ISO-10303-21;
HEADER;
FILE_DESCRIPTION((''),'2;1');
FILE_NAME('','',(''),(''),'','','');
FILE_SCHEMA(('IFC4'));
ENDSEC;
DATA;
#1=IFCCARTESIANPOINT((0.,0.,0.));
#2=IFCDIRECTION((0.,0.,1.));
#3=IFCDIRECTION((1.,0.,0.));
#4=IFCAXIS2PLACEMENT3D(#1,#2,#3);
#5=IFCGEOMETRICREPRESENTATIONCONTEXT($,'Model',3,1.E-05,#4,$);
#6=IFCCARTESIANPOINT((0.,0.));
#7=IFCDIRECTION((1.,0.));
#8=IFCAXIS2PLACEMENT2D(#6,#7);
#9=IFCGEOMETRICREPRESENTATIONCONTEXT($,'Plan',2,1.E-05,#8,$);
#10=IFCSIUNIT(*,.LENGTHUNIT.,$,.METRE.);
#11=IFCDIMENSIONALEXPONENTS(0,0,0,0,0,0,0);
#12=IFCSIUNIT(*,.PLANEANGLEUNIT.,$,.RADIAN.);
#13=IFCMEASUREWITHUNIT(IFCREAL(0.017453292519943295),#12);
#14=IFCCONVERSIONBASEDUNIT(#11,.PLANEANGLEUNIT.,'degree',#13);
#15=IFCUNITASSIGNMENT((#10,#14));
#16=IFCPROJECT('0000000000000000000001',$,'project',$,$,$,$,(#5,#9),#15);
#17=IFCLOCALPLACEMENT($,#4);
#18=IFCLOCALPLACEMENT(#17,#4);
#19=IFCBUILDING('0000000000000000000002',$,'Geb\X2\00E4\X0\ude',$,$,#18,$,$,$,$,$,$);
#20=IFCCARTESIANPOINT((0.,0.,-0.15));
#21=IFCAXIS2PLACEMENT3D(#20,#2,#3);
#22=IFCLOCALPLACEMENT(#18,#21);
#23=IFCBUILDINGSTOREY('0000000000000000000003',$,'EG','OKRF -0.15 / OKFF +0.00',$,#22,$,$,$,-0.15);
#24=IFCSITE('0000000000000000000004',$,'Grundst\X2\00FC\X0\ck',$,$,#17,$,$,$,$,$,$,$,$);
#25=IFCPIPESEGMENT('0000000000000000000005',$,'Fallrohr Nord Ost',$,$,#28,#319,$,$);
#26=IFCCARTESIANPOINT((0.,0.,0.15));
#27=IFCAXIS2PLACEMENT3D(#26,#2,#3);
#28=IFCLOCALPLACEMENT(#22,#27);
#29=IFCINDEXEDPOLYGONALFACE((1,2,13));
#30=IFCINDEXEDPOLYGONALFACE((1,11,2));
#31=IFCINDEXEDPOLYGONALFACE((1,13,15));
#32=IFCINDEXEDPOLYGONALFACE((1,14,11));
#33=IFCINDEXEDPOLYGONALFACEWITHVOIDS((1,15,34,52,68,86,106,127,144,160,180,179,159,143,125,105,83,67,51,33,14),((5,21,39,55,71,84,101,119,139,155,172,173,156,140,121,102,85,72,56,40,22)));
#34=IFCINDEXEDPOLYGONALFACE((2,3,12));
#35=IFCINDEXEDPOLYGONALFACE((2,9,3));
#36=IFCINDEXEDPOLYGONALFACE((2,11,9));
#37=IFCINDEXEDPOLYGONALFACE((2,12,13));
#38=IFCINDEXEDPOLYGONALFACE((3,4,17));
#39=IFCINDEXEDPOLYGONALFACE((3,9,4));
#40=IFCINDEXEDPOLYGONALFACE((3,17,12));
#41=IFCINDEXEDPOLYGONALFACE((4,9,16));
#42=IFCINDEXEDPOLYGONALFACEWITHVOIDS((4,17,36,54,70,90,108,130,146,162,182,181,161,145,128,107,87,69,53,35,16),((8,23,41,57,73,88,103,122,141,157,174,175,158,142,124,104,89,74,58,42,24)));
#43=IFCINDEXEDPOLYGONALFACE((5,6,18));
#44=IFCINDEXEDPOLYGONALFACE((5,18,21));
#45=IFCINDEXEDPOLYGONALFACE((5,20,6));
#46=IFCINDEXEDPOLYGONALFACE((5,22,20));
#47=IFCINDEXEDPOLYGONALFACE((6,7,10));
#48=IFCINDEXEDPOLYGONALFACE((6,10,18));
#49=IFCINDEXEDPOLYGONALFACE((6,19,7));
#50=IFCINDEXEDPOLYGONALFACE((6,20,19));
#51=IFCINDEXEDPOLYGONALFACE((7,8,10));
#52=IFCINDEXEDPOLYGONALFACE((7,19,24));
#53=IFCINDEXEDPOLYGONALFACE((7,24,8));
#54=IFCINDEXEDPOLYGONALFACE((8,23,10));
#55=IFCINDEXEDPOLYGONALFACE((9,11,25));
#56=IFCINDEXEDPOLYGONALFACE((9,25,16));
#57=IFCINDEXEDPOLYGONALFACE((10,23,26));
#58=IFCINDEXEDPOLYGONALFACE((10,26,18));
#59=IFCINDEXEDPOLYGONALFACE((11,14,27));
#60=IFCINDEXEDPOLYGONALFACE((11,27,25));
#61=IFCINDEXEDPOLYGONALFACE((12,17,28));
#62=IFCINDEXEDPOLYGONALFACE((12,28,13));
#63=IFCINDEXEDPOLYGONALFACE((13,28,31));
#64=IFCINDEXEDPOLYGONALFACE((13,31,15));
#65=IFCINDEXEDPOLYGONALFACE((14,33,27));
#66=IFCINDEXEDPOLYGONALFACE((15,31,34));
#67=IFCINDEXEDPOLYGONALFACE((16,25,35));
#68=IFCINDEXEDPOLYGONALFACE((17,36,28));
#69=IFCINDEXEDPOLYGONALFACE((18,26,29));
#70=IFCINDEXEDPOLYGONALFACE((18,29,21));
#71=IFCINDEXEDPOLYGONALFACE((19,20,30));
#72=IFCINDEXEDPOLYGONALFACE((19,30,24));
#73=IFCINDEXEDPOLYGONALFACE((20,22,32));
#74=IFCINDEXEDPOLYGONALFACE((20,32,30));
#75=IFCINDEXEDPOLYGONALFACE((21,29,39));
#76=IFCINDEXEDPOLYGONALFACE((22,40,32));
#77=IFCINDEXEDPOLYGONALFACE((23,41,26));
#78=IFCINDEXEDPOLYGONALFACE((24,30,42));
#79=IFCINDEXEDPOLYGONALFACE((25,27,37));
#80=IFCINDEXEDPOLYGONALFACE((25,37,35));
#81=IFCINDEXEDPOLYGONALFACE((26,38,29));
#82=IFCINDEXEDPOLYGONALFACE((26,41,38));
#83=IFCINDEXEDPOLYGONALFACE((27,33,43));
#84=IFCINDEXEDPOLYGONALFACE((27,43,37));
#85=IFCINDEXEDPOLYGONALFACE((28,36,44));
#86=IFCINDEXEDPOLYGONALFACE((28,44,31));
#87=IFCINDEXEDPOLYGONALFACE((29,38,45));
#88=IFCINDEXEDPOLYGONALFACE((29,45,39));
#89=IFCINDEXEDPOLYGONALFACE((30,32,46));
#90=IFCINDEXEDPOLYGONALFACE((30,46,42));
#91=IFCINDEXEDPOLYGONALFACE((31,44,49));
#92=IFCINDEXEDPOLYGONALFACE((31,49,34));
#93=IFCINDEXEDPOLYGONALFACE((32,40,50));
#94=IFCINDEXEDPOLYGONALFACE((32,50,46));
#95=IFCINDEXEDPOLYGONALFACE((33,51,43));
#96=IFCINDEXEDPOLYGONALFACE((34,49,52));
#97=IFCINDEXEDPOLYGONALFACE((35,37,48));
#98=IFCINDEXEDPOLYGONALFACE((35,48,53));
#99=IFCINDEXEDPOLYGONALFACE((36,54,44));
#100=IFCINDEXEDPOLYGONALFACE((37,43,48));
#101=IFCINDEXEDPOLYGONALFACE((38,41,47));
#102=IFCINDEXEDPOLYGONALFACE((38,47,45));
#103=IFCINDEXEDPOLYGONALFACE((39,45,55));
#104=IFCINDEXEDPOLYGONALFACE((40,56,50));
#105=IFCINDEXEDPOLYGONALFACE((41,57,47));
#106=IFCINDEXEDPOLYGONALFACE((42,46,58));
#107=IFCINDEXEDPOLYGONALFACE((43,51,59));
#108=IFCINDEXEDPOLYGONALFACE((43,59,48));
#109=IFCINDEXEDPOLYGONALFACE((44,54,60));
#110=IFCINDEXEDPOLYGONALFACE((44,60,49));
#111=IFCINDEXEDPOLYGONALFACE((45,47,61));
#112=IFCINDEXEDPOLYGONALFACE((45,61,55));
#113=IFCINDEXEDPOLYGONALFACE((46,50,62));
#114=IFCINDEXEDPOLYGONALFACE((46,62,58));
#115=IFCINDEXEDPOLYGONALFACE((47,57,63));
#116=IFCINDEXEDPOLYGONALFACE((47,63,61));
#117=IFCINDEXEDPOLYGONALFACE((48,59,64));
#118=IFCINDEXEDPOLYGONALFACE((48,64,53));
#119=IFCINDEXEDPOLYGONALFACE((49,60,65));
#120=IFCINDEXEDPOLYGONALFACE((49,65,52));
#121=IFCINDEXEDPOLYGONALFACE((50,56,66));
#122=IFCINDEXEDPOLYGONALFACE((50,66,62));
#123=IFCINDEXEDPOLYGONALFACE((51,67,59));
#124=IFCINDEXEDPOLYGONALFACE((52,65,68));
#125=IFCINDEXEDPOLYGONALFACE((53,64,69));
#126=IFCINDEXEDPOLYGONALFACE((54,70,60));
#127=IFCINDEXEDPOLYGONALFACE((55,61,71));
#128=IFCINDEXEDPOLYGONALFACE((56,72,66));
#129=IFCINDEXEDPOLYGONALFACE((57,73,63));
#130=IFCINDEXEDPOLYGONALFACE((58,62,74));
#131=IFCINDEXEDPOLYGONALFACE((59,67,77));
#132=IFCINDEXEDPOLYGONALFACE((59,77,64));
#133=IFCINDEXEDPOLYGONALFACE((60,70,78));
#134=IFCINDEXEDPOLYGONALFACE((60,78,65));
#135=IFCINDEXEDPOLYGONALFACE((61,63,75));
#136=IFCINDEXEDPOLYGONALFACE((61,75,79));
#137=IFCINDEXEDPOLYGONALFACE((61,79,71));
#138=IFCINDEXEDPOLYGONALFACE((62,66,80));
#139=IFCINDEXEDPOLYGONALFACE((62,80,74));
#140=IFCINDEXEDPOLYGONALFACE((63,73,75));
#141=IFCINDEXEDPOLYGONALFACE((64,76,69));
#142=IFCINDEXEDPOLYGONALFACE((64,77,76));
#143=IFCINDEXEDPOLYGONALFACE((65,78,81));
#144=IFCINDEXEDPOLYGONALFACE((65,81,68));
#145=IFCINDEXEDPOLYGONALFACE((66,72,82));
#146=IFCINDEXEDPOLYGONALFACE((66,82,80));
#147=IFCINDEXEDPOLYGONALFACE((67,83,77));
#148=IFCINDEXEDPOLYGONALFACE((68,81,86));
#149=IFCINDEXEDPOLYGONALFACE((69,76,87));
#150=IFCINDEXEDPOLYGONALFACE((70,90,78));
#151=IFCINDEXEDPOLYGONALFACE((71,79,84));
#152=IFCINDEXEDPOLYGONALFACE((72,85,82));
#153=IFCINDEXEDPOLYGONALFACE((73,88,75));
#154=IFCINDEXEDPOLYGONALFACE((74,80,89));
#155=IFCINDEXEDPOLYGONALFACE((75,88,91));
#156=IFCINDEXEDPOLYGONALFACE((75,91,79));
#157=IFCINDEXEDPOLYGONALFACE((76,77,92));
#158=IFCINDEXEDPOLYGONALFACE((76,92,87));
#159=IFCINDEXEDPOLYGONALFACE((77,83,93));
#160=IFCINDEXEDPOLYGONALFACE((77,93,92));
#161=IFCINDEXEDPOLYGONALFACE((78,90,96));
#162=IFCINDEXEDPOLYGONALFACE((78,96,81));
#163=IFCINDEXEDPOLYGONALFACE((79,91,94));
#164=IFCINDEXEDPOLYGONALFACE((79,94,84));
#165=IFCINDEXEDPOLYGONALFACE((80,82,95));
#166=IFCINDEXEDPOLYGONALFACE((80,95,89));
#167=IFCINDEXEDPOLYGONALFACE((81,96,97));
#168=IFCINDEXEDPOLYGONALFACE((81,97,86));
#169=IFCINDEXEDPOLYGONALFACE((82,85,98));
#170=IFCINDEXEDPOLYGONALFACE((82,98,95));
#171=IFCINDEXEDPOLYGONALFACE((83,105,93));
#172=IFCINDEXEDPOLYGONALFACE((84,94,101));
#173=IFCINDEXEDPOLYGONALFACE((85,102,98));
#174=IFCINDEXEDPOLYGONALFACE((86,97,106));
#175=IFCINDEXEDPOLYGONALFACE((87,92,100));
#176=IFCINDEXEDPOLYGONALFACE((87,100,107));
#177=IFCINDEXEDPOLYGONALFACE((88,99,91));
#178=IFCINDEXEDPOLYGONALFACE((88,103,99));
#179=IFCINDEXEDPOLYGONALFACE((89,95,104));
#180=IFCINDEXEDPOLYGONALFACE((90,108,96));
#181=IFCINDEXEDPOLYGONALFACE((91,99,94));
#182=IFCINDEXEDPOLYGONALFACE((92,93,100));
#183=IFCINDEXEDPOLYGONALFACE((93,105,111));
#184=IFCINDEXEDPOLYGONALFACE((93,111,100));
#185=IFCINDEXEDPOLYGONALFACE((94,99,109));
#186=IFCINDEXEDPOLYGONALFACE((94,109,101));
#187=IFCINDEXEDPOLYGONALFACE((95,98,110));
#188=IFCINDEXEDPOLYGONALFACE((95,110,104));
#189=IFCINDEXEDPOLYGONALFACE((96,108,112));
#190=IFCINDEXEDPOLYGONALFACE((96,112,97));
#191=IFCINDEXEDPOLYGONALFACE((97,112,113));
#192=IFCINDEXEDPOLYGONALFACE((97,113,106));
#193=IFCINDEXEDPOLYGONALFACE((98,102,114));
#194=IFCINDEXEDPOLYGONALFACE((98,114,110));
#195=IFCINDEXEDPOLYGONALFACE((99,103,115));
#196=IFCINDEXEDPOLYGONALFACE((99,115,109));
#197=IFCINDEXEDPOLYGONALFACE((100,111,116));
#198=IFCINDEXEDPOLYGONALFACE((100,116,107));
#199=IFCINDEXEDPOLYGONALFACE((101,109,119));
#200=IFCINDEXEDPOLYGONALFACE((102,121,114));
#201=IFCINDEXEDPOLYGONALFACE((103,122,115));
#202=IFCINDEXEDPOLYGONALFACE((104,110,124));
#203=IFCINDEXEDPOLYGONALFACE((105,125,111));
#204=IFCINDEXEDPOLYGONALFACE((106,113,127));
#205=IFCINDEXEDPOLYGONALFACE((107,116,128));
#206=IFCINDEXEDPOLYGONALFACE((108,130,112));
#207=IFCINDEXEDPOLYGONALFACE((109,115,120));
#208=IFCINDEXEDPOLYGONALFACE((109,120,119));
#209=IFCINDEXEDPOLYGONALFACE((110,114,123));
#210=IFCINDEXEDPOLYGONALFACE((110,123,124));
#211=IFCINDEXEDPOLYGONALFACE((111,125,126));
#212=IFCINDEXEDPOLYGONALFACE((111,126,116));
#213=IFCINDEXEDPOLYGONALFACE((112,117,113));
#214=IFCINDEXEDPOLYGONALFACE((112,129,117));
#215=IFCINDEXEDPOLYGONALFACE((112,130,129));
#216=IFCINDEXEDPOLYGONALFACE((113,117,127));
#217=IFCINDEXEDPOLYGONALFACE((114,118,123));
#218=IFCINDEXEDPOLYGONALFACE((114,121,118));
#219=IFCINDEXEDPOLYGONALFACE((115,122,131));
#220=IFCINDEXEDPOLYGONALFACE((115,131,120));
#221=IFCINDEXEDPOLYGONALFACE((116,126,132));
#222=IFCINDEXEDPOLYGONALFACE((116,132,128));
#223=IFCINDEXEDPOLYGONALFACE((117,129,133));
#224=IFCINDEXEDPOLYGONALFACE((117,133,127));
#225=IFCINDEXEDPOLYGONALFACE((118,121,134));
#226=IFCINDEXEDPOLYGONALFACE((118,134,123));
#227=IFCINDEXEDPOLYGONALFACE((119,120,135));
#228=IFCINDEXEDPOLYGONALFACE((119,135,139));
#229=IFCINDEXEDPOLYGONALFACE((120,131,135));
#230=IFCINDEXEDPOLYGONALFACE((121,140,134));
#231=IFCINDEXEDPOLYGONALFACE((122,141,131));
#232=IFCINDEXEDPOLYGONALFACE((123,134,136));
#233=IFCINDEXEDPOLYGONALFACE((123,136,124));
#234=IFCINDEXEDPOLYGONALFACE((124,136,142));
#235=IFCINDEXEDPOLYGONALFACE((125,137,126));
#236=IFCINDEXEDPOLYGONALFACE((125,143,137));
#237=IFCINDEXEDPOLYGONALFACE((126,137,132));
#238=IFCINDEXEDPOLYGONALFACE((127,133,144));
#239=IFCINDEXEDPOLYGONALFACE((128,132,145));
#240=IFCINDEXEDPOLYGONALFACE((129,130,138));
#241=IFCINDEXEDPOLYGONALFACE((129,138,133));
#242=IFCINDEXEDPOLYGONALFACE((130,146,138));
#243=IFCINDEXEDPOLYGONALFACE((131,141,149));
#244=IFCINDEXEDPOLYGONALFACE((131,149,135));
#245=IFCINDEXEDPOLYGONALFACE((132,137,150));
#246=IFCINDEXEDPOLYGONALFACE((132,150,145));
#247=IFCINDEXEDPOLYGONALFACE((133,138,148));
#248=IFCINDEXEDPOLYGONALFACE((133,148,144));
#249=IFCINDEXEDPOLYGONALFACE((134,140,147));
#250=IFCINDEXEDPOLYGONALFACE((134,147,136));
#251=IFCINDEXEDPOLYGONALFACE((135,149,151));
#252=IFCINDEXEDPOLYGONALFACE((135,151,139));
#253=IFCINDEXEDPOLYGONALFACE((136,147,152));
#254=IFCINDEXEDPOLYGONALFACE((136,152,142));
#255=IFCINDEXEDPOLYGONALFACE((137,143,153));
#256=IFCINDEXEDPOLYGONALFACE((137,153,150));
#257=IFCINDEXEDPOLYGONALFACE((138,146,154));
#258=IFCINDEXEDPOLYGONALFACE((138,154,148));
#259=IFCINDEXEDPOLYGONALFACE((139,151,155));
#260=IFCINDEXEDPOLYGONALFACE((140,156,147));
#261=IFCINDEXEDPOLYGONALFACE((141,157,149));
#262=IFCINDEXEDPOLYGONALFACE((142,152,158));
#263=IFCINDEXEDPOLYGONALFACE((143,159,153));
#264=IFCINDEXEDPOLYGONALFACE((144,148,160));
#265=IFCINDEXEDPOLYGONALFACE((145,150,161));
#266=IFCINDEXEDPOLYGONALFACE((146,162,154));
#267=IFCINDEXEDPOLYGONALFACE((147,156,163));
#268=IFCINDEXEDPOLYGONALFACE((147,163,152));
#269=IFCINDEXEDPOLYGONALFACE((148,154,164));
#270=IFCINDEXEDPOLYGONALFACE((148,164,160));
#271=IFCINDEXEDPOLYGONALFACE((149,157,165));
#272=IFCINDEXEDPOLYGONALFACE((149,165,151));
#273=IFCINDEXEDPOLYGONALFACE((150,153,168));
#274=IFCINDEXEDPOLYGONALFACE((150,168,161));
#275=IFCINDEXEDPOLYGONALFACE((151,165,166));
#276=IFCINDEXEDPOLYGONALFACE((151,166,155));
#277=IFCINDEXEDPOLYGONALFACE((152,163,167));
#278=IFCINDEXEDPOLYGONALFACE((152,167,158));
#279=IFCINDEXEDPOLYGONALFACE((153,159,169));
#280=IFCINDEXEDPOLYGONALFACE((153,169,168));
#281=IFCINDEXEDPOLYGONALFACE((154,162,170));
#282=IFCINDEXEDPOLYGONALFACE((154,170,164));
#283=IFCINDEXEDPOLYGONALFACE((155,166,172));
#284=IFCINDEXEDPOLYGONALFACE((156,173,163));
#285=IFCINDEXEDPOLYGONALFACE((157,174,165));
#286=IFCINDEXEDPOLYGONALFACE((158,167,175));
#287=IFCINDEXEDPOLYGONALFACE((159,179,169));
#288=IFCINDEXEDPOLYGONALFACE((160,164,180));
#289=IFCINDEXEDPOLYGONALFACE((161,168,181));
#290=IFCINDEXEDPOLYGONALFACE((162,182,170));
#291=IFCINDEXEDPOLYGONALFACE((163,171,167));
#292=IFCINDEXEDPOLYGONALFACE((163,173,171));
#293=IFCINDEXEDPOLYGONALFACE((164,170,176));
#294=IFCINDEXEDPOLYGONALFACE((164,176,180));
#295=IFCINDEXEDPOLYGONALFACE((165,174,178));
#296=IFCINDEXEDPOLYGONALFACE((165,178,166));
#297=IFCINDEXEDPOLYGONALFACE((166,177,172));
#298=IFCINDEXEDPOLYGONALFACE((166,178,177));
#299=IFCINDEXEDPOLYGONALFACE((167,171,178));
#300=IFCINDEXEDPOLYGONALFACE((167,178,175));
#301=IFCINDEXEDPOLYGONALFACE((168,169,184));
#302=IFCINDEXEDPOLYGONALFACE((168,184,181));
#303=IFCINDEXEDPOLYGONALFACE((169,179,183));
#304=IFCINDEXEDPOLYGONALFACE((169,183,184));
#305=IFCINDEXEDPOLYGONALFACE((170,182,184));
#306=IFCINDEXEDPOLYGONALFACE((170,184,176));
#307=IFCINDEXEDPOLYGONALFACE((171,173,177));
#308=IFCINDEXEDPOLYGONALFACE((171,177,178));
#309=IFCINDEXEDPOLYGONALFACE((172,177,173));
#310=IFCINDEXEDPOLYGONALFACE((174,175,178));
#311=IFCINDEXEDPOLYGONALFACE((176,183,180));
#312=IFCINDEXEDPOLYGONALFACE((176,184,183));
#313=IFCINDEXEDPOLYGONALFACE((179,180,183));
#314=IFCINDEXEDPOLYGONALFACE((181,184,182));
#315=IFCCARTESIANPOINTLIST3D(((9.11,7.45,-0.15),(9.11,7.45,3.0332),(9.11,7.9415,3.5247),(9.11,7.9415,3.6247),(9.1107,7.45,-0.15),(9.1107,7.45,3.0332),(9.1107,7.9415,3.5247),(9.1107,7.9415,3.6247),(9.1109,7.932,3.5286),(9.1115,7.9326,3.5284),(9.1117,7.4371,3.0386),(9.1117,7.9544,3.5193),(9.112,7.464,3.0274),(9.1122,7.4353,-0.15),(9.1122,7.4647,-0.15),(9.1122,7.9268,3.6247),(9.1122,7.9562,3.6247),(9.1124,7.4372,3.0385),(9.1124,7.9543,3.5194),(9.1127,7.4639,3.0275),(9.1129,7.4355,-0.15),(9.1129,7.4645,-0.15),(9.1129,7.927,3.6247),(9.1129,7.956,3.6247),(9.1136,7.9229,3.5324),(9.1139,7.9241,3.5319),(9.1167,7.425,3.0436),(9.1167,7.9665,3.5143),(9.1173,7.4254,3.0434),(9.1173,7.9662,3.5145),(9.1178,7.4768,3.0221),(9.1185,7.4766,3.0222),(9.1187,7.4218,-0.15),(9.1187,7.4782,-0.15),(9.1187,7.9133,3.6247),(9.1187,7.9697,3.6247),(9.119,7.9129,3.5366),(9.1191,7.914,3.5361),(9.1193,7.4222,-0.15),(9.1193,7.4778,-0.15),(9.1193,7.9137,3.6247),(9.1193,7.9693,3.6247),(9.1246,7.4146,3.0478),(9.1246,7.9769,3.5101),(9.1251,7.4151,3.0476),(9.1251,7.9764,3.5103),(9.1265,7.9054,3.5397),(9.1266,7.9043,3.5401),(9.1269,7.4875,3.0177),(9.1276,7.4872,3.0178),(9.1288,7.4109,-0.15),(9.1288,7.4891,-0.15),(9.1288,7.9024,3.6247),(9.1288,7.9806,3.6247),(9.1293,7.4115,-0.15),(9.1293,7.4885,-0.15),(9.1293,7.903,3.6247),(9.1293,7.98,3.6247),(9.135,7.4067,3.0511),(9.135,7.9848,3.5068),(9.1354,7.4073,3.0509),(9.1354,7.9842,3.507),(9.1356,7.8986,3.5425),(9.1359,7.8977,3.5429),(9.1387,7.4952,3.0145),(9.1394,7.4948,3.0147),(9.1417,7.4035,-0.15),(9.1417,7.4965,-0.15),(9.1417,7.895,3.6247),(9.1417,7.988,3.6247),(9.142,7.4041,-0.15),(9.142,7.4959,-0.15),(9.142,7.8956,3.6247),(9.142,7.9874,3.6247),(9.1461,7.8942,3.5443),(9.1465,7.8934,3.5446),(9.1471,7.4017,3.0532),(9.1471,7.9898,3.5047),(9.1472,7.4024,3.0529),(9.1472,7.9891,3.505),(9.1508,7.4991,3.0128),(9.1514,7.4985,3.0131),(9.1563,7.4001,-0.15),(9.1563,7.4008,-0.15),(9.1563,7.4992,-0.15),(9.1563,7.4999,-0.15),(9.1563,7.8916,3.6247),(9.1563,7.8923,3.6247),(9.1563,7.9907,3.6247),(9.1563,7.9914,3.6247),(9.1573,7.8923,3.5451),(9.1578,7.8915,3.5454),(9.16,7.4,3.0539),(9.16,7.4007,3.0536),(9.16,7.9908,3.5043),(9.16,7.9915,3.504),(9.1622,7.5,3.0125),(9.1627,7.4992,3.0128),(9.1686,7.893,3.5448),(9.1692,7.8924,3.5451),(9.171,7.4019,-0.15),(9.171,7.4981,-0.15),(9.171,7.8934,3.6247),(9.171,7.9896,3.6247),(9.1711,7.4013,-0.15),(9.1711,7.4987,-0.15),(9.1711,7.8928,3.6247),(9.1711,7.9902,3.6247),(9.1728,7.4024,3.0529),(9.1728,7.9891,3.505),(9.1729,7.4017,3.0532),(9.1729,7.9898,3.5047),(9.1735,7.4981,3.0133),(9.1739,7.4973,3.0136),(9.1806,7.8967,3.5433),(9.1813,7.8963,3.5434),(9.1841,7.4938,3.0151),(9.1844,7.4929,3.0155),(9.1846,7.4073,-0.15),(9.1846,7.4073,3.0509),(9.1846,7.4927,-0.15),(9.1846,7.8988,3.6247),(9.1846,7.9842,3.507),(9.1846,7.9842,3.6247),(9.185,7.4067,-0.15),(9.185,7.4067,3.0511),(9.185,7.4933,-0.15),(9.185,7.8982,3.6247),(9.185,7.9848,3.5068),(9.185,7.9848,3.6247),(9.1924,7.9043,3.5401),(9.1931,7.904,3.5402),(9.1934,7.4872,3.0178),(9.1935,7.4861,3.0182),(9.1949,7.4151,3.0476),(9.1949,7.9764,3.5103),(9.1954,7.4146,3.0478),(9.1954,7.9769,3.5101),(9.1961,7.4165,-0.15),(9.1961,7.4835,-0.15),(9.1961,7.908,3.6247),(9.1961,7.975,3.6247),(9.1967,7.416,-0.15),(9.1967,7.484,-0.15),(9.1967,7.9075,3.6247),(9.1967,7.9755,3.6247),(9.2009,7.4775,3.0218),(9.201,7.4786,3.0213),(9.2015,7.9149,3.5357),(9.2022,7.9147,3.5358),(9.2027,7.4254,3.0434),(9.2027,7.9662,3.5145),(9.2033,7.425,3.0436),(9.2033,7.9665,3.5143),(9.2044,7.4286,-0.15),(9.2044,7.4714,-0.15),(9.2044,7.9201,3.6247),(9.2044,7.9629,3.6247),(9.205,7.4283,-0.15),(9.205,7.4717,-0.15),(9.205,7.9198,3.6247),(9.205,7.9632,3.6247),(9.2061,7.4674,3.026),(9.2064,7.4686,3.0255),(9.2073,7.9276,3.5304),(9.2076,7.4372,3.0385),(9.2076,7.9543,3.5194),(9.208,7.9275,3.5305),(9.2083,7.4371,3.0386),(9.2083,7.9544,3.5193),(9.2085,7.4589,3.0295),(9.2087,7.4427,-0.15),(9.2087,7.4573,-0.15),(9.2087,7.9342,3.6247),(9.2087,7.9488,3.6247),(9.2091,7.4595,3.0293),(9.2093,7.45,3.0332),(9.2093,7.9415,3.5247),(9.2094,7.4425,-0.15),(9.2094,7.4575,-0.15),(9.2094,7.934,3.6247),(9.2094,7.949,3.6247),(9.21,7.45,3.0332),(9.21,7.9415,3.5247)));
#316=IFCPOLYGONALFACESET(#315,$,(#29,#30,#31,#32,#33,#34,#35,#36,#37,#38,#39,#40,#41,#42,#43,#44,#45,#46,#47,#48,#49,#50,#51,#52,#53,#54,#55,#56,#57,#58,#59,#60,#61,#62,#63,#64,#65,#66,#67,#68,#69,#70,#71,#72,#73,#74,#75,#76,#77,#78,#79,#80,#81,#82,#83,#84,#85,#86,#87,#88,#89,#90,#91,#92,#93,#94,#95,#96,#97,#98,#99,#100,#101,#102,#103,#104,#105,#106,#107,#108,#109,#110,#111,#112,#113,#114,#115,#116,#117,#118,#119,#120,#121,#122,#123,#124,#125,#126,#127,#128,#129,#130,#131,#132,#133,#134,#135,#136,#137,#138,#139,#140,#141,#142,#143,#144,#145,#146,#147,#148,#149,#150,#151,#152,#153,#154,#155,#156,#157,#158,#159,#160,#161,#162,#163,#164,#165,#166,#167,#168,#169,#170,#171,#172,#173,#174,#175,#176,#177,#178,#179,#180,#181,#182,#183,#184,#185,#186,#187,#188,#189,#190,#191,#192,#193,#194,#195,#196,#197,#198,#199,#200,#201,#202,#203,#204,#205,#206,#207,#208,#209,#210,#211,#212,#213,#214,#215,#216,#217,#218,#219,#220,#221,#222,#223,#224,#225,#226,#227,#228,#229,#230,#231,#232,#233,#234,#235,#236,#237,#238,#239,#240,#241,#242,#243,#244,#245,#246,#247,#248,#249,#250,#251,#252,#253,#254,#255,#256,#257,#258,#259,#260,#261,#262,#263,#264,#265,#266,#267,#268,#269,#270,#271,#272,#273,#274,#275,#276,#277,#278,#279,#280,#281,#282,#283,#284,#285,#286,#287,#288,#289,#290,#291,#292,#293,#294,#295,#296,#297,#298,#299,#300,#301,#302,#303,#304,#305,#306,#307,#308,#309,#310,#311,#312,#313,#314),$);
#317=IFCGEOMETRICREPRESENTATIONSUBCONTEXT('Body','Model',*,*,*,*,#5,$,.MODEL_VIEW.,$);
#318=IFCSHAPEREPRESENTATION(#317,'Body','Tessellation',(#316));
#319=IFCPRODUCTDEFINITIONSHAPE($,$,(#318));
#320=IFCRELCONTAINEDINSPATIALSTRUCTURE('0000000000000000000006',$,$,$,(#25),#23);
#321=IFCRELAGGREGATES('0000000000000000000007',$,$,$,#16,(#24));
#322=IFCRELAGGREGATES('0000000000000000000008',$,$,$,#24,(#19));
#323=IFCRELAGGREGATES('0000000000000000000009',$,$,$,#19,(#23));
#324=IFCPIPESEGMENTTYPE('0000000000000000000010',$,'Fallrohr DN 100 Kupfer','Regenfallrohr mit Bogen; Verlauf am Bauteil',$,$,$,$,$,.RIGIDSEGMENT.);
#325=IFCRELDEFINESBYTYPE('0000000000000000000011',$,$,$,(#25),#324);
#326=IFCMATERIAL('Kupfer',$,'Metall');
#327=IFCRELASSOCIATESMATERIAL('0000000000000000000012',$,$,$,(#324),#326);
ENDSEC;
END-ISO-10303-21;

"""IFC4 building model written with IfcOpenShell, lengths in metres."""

from ifc_helpers import new_model, entity, si_unit, converted_unit, frame, origin_with_axes, origin_2d_with_axis, place, context, subcontext, project, spatial, material, type_object, element, save


model = new_model("IFC4")

# Units and contexts
model_context = context("Model", 3, precision=1e-05, world=origin_with_axes())
plan_context = context("Plan", 2, precision=1e-05, world=origin_2d_with_axis())
body_context = subcontext(model_context, "Body", "Model", "MODEL_VIEW")
ifc_project = project(units=[si_unit("LENGTHUNIT", "METRE"), converted_unit("PLANEANGLEUNIT", "degree", entity("IfcReal", 0.017453292519943295), si_unit("PLANEANGLEUNIT", "RADIAN"), dimensions=[0, 0, 0, 0, 0, 0, 0])], contexts=[model_context, plan_context])

# Site, building, storey
site_placement = place(None, origin_with_axes())
site = spatial("IfcSite", under=ifc_project, at=site_placement, Name="Grundstück")
building_placement = place(site_placement, origin_with_axes())
building = spatial("IfcBuilding", under=site, at=building_placement, Name="Gebäude")
storey_placement = place(building_placement, frame((0.0, 0.0, -0.15), z_axis=(0.0, 0.0, 1.0), x_axis=(1.0, 0.0, 0.0)))
storey = spatial("IfcBuildingStorey", under=building, at=storey_placement, Name="EG", Description="OKRF -0.15 / OKFF +0.00", Elevation=-0.15)

# Pipe segment
ifc_material_1 = material(Name="Kupfer", Category="Metall")
pipe_segment_type = type_object("IfcPipeSegmentType", Name="Fallrohr DN 100 Kupfer", Description="Regenfallrohr mit Bogen; Verlauf am Bauteil", PredefinedType="RIGIDSEGMENT", material=ifc_material_1)
pipe_segment_1_placement = place(storey_placement, frame((0.0, 0.0, 0.15), z_axis=(0.0, 0.0, 1.0), x_axis=(1.0, 0.0, 0.0)))
element("IfcPipeSegment", 1, at=pipe_segment_1_placement, inside=storey, type_object=pipe_segment_type, Name="Fallrohr Nord Ost", context=body_context, shape_type="AdvancedSweptSolid", body=[
    entity("IfcSweptDiskSolid", entity("IfcPolyline", [entity("IfcCartesianPoint", [9.16, 7.9415, 3.6247]), entity("IfcCartesianPoint", [9.16, 7.9415, 3.5247]), entity("IfcCartesianPoint", [9.16, 7.45, 3.0332]), entity("IfcCartesianPoint", [9.16, 7.45, -0.15])]), 0.05, 0.0493),
])

save(model, "model.ifc")
